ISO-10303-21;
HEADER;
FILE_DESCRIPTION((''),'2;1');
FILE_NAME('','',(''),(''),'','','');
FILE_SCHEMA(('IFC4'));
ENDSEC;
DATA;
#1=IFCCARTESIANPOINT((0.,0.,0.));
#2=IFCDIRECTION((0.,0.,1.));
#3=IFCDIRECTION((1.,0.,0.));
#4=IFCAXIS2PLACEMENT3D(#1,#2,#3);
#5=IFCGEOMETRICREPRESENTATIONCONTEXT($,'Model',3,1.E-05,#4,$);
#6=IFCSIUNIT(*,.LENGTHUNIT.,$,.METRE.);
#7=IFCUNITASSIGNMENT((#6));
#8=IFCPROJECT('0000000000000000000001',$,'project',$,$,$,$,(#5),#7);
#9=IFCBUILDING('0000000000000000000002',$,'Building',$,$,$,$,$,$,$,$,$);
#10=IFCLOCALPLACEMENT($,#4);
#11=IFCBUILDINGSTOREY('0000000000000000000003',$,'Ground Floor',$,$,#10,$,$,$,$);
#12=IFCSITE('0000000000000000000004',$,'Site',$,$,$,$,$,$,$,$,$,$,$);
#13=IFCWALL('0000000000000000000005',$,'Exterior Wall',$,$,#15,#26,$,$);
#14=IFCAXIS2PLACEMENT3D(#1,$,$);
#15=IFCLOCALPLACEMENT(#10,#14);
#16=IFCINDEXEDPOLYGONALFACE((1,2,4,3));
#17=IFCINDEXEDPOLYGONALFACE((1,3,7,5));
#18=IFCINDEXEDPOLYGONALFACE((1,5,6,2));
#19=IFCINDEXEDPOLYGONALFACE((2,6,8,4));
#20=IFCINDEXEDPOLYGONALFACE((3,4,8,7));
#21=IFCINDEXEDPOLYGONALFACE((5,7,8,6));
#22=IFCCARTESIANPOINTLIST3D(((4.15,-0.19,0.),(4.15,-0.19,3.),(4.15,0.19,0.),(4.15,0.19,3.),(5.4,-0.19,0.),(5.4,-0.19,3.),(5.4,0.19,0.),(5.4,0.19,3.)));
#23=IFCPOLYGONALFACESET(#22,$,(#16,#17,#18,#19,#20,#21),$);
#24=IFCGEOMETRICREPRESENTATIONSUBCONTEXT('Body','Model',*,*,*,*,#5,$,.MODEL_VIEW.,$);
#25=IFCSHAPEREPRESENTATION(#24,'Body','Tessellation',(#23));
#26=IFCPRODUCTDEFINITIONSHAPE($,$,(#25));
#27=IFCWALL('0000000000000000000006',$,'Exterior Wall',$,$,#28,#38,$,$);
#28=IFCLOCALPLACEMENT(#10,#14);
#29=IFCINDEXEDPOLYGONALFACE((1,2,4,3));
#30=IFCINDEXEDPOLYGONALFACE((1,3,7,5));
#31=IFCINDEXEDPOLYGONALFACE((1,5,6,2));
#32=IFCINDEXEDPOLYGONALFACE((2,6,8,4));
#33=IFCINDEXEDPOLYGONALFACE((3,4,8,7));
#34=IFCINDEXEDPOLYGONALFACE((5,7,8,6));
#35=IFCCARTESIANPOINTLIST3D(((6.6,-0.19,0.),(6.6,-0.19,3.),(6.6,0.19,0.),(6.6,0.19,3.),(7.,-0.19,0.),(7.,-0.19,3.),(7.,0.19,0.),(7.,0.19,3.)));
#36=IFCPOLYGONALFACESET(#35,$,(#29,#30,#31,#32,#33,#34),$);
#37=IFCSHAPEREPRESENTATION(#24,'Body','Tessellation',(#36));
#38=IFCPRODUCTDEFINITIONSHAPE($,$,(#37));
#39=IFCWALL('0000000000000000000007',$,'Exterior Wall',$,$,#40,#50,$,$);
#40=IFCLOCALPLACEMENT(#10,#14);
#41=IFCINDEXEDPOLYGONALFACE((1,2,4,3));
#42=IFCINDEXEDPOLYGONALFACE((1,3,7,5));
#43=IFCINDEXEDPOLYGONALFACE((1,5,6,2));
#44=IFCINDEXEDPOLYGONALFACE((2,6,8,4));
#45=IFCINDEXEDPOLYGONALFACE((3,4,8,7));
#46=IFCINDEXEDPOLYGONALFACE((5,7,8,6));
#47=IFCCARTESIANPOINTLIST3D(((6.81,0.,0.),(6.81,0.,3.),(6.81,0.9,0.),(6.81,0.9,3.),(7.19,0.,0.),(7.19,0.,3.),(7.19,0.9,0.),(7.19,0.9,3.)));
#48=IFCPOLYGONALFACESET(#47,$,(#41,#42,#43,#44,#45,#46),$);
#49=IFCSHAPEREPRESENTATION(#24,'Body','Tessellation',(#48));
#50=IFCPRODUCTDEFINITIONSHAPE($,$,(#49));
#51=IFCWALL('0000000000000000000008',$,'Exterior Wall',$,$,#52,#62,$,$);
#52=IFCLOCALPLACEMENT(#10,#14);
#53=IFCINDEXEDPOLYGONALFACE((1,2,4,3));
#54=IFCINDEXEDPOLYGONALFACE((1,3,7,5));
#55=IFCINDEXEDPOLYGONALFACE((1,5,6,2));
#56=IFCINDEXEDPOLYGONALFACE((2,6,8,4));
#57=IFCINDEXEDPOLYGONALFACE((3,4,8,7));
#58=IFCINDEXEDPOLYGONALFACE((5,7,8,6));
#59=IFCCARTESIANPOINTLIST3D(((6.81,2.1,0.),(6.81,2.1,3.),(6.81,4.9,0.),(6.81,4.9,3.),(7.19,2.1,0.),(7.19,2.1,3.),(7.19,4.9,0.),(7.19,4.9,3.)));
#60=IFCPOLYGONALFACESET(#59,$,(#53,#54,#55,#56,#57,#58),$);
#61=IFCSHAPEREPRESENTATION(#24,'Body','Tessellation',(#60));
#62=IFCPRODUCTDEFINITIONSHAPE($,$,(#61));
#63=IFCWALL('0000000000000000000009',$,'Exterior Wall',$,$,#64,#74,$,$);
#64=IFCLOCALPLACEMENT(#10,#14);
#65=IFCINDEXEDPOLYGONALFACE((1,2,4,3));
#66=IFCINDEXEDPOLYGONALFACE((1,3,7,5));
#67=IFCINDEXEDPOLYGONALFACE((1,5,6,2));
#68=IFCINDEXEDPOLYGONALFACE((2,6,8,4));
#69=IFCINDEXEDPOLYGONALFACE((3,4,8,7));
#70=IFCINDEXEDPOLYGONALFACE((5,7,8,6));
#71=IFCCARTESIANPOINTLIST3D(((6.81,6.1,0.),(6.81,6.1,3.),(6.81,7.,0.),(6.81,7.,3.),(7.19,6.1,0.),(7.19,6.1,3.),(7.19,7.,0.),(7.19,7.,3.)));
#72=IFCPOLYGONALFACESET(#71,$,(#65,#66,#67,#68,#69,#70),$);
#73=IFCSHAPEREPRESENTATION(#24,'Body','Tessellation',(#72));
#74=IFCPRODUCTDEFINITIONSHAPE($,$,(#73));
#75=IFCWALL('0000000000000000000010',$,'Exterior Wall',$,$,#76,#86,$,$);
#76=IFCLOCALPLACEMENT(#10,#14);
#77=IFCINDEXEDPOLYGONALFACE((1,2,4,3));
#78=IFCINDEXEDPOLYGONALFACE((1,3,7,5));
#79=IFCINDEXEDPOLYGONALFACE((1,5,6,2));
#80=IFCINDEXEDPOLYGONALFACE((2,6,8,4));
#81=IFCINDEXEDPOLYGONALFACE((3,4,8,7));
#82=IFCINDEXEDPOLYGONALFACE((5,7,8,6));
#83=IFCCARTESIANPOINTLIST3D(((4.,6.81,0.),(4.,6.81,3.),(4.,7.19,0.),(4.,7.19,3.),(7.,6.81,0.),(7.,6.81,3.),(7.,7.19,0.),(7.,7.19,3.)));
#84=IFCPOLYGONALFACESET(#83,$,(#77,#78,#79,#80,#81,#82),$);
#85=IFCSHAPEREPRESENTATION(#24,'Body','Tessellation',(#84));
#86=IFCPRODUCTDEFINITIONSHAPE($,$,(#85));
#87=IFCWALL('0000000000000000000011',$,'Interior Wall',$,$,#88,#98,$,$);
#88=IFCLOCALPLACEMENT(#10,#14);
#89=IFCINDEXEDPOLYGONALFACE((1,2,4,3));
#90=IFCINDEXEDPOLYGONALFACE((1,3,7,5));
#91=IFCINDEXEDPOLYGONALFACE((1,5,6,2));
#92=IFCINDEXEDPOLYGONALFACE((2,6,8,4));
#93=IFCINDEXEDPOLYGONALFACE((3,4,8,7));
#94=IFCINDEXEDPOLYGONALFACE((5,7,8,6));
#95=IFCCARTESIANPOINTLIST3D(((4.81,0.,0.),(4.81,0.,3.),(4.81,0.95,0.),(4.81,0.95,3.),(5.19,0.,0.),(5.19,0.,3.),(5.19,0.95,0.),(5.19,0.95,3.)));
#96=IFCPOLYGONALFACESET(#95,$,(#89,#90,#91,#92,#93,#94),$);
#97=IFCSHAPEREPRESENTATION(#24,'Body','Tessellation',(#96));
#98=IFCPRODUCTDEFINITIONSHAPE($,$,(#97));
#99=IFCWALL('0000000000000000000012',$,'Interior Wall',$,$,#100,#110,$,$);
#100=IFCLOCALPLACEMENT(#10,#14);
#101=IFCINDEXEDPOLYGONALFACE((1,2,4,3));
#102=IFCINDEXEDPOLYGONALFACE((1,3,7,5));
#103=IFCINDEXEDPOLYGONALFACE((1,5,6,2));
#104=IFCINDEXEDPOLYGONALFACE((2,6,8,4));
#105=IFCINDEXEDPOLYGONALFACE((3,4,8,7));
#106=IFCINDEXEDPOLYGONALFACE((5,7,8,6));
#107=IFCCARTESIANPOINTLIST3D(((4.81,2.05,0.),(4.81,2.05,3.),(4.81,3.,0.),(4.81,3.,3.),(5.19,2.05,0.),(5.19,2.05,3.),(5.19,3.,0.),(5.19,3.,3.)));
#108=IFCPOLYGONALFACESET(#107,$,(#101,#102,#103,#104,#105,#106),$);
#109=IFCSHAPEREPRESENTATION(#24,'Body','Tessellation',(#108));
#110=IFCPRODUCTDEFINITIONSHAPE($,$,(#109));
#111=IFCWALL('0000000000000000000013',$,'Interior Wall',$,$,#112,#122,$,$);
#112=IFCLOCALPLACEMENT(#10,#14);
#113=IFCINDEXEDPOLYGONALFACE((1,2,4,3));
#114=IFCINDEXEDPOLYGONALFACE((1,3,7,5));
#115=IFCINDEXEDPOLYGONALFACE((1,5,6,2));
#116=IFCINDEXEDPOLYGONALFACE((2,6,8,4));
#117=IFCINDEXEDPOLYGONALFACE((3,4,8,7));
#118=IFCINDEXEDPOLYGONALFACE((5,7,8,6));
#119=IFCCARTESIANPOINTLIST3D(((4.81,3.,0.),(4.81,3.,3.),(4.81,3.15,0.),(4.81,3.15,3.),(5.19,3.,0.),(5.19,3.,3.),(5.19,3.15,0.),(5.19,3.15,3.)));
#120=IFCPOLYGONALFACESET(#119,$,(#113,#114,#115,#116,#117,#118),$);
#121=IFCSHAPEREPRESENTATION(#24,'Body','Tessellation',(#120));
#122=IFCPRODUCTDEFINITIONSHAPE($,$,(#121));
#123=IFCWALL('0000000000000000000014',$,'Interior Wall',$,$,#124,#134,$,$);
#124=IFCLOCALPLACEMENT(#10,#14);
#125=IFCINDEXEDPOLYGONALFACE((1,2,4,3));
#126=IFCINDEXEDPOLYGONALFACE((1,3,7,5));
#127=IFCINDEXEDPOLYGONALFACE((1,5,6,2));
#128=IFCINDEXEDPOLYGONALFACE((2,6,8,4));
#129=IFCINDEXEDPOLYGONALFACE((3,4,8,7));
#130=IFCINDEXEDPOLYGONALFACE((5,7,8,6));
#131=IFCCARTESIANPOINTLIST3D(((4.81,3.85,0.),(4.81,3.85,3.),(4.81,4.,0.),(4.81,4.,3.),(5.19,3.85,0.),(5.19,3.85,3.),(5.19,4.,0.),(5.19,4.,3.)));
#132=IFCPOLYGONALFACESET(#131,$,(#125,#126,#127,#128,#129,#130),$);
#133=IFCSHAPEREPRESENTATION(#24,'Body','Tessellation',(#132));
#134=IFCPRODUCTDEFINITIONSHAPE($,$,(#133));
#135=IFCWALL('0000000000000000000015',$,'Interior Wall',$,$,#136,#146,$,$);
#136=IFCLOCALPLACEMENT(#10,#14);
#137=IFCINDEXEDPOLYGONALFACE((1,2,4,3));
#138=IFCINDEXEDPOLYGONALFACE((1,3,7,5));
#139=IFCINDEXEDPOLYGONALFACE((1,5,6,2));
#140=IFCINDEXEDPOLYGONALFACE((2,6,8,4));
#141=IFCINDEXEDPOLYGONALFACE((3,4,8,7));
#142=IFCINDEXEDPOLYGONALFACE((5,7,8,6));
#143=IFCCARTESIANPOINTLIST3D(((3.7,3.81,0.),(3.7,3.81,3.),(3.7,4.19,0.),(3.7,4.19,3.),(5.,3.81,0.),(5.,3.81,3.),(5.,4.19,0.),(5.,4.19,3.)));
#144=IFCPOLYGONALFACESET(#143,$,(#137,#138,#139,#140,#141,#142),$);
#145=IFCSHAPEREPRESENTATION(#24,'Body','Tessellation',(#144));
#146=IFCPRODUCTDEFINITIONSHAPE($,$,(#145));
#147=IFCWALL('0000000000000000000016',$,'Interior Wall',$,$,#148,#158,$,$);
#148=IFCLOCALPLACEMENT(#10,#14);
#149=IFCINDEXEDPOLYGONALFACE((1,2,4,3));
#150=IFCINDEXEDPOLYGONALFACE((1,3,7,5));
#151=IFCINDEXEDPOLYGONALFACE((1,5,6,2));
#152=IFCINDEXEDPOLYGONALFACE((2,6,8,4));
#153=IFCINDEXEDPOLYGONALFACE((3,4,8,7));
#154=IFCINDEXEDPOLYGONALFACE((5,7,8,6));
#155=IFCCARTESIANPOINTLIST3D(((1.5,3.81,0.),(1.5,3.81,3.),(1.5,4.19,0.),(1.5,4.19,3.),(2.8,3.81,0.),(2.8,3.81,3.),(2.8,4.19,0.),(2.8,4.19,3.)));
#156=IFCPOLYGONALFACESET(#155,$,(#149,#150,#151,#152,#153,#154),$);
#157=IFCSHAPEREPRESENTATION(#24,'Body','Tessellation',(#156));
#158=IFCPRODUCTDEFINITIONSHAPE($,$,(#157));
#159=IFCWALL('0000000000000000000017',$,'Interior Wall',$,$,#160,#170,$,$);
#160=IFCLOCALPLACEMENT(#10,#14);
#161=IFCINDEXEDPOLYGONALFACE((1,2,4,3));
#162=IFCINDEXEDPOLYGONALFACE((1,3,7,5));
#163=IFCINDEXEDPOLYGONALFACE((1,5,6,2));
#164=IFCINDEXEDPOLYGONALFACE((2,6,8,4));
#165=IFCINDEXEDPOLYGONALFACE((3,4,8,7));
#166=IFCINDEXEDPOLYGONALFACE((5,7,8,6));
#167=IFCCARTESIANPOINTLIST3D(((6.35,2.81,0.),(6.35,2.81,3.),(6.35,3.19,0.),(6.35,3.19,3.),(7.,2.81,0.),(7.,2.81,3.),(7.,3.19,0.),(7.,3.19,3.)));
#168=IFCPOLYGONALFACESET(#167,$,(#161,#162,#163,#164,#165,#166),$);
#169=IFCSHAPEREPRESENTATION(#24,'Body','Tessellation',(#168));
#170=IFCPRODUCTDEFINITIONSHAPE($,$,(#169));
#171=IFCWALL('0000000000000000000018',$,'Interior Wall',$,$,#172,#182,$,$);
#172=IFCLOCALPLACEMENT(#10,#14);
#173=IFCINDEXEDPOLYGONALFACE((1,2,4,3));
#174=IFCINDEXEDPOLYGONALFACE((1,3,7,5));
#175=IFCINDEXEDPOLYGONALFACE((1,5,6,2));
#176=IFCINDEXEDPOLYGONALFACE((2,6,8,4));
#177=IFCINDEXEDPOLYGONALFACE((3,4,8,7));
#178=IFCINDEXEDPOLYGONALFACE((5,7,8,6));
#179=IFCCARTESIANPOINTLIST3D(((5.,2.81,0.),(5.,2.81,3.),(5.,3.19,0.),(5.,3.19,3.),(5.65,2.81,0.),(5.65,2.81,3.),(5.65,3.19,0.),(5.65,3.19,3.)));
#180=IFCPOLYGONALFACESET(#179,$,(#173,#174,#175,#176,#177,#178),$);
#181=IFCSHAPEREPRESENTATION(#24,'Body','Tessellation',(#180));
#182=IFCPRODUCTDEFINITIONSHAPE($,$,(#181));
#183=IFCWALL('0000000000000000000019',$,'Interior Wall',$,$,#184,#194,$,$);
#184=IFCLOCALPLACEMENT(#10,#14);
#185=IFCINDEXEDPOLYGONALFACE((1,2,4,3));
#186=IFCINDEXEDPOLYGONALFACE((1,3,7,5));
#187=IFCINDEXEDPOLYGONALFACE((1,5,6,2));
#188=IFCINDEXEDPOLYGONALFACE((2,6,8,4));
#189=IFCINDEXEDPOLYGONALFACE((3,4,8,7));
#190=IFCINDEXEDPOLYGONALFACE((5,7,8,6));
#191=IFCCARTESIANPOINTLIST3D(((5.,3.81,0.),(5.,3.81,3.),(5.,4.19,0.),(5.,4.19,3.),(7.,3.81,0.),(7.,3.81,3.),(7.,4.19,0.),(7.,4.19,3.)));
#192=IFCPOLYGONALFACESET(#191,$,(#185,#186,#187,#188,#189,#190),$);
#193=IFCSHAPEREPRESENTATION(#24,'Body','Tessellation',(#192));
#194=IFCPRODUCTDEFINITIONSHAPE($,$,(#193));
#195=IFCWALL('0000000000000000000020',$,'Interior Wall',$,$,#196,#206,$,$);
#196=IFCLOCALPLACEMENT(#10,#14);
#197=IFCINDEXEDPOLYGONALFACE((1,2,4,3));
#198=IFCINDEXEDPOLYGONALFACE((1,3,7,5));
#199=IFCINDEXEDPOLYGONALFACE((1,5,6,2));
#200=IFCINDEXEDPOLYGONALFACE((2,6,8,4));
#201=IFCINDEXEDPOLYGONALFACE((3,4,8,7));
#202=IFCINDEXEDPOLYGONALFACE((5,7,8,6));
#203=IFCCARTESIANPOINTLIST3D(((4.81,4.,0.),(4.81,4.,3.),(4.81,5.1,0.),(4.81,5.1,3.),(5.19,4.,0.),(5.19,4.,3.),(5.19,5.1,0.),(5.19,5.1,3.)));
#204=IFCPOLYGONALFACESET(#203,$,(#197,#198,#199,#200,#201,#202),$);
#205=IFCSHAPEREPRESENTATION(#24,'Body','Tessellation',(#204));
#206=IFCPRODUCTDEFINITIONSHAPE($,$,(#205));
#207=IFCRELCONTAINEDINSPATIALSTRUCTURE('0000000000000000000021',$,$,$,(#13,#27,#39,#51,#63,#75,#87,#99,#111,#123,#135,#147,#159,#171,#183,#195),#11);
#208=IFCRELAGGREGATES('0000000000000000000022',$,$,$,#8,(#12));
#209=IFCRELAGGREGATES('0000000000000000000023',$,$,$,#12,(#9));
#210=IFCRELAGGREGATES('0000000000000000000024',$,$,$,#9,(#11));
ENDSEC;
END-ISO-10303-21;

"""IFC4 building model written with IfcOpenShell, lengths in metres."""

from ifc_helpers import new_model, si_unit, frame, origin_with_axes, place, context, subcontext, project, spatial, indexed_curve, outline, extrude, element, save


model = new_model("IFC4")

# Units and contexts
model_context = context("Model", 3, precision=1e-05, world=origin_with_axes())
body_context = subcontext(model_context, "Body", "Model", "MODEL_VIEW")
ifc_project = project(units=[si_unit("LENGTHUNIT", "METRE")], contexts=[model_context])

# Site, building, storey
site = spatial("IfcSite", under=ifc_project, Name="Site")
building = spatial("IfcBuilding", under=site, Name="Building")
storey_placement = place(None, origin_with_axes())
storey = spatial("IfcBuildingStorey", under=building, at=storey_placement, Name="Ground Floor")

# Walls
wall_1_placement = place(storey_placement, frame((4.15, 0.0, 0.0), z_axis=(0.0, 0.0, 1.0), x_axis=(1.0, 0.0, 0.0)))
element("IfcWall", 1, at=wall_1_placement, inside=storey, Name="Exterior Wall", context=body_context, shape_type="SweptSolid", body=[
    extrude(outline(indexed_curve([(0.0, 0.0), (0.0, 0.38), (1.25, 0.38), (1.25, 0.0), (0.0, 0.0)], self_intersect=False)), frame((0.0, -0.19, 0.0), z_axis=(0.0, 0.0, 1.0), x_axis=(1.0, 0.0, 0.0)), (0.0, 0.0, 1.0), 3.0),
])
wall_2_placement = place(storey_placement, frame((6.6, 0.0, 0.0), z_axis=(0.0, 0.0, 1.0), x_axis=(1.0, 0.0, 0.0)))
element("IfcWall", 2, at=wall_2_placement, inside=storey, Name="Exterior Wall", context=body_context, shape_type="SweptSolid", body=[
    extrude(outline(indexed_curve([(0.0, 0.0), (0.0, 0.38), (0.4, 0.38), (0.4, 0.0), (0.0, 0.0)], self_intersect=False)), frame((0.0, -0.19, 0.0), z_axis=(0.0, 0.0, 1.0), x_axis=(1.0, 0.0, 0.0)), (0.0, 0.0, 1.0), 3.0),
])
wall_3_placement = place(storey_placement, frame((7.0, 0.0, 0.0), z_axis=(0.0, 0.0, 1.0), x_axis=(0.0, 1.0, 0.0)))
element("IfcWall", 3, at=wall_3_placement, inside=storey, Name="Exterior Wall", context=body_context, shape_type="SweptSolid", body=[
    extrude(outline(indexed_curve([(0.0, 0.0), (0.0, 0.38), (0.9, 0.38), (0.9, 0.0), (0.0, 0.0)], self_intersect=False)), frame((0.0, -0.19, 0.0), z_axis=(0.0, 0.0, 1.0), x_axis=(1.0, 0.0, 0.0)), (0.0, 0.0, 1.0), 3.0),
])
wall_4_placement = place(storey_placement, frame((7.0, 2.1, 0.0), z_axis=(0.0, 0.0, 1.0), x_axis=(0.0, 1.0, 0.0)))
element("IfcWall", 4, at=wall_4_placement, inside=storey, Name="Exterior Wall", context=body_context, shape_type="SweptSolid", body=[
    extrude(outline(indexed_curve([(0.0, 0.0), (0.0, 0.38), (2.8, 0.38), (2.8, 0.0), (0.0, 0.0)], self_intersect=False)), frame((0.0, -0.19, 0.0), z_axis=(0.0, 0.0, 1.0), x_axis=(1.0, 0.0, 0.0)), (0.0, 0.0, 1.0), 3.0),
])
wall_5_placement = place(storey_placement, frame((7.0, 6.1, 0.0), z_axis=(0.0, 0.0, 1.0), x_axis=(0.0, 1.0, 0.0)))
element("IfcWall", 5, at=wall_5_placement, inside=storey, Name="Exterior Wall", context=body_context, shape_type="SweptSolid", body=[
    extrude(outline(indexed_curve([(0.0, 0.0), (0.0, 0.38), (0.9, 0.38), (0.9, 0.0), (0.0, 0.0)], self_intersect=False)), frame((0.0, -0.19, 0.0), z_axis=(0.0, 0.0, 1.0), x_axis=(1.0, 0.0, 0.0)), (0.0, 0.0, 1.0), 3.0),
])
wall_6_placement = place(storey_placement, frame((7.0, 7.0, 0.0), z_axis=(0.0, 0.0, 1.0), x_axis=(-1.0, 0.0, 0.0)))
element("IfcWall", 6, at=wall_6_placement, inside=storey, Name="Exterior Wall", context=body_context, shape_type="SweptSolid", body=[
    extrude(outline(indexed_curve([(0.0, 0.0), (0.0, 0.38), (3.0, 0.38), (3.0, 0.0), (0.0, 0.0)], self_intersect=False)), frame((0.0, -0.19, 0.0), z_axis=(0.0, 0.0, 1.0), x_axis=(1.0, 0.0, 0.0)), (0.0, 0.0, 1.0), 3.0),
])
wall_7_placement = place(storey_placement, frame((5.0, 0.0, 0.0), z_axis=(0.0, 0.0, 1.0), x_axis=(0.0, 1.0, 0.0)))
element("IfcWall", 7, at=wall_7_placement, inside=storey, Name="Interior Wall", context=body_context, shape_type="SweptSolid", body=[
    extrude(outline(indexed_curve([(0.0, 0.0), (0.0, 0.38), (0.95, 0.38), (0.95, 0.0), (0.0, 0.0)], self_intersect=False)), frame((0.0, -0.19, 0.0), z_axis=(0.0, 0.0, 1.0), x_axis=(1.0, 0.0, 0.0)), (0.0, 0.0, 1.0), 3.0),
])
wall_8_placement = place(storey_placement, frame((5.0, 2.05, 0.0), z_axis=(0.0, 0.0, 1.0), x_axis=(0.0, 1.0, 0.0)))
element("IfcWall", 8, at=wall_8_placement, inside=storey, Name="Interior Wall", context=body_context, shape_type="SweptSolid", body=[
    extrude(outline(indexed_curve([(0.0, 0.0), (0.0, 0.38), (0.95, 0.38), (0.95, 0.0), (0.0, 0.0)], self_intersect=False)), frame((0.0, -0.19, 0.0), z_axis=(0.0, 0.0, 1.0), x_axis=(1.0, 0.0, 0.0)), (0.0, 0.0, 1.0), 3.0),
])
for number, where, z_axis, x_axis, name in (
    (9, (5.0, 3.0, 0.0), (0.0, 0.0, 1.0), (0.0, 1.0, 0.0), "Interior Wall"),
    (10, (5.0, 3.85, 0.0), (0.0, 0.0, 1.0), (0.0, 1.0, 0.0), "Interior Wall"),
):
    element("IfcWall", number, at=place(storey_placement, frame(where, z_axis=z_axis, x_axis=x_axis)), inside=storey, Name=name, context=body_context, shape_type="SweptSolid", body=[
        extrude(outline(indexed_curve([(0.0, 0.0), (0.0, 0.38), (0.15, 0.38), (0.15, 0.0), (0.0, 0.0)], self_intersect=False)), frame((0.0, -0.19, 0.0), z_axis=(0.0, 0.0, 1.0), x_axis=(1.0, 0.0, 0.0)), (0.0, 0.0, 1.0), 3.0),
    ])
for number, where, z_axis, x_axis, name in (
    (11, (5.0, 4.0, 0.0), (0.0, 0.0, 1.0), (-1.0, 0.0, 0.0), "Interior Wall"),
    (12, (2.8, 4.0, 0.0), (0.0, 0.0, 1.0), (-1.0, 0.0, 0.0), "Interior Wall"),
):
    element("IfcWall", number, at=place(storey_placement, frame(where, z_axis=z_axis, x_axis=x_axis)), inside=storey, Name=name, context=body_context, shape_type="SweptSolid", body=[
        extrude(outline(indexed_curve([(0.0, 0.0), (0.0, 0.38), (1.3, 0.38), (1.3, 0.0), (0.0, 0.0)], self_intersect=False)), frame((0.0, -0.19, 0.0), z_axis=(0.0, 0.0, 1.0), x_axis=(1.0, 0.0, 0.0)), (0.0, 0.0, 1.0), 3.0),
    ])
for number, where, z_axis, x_axis, name in (
    (13, (7.0, 3.0, 0.0), (0.0, 0.0, 1.0), (-1.0, 0.0, 0.0), "Interior Wall"),
    (14, (5.65, 3.0, 0.0), (0.0, 0.0, 1.0), (-1.0, 0.0, 0.0), "Interior Wall"),
):
    element("IfcWall", number, at=place(storey_placement, frame(where, z_axis=z_axis, x_axis=x_axis)), inside=storey, Name=name, context=body_context, shape_type="SweptSolid", body=[
        extrude(outline(indexed_curve([(0.0, 0.0), (0.0, 0.38), (0.65, 0.38), (0.65, 0.0), (0.0, 0.0)], self_intersect=False)), frame((0.0, -0.19, 0.0), z_axis=(0.0, 0.0, 1.0), x_axis=(1.0, 0.0, 0.0)), (0.0, 0.0, 1.0), 3.0),
    ])
wall_9_placement = place(storey_placement, frame((7.0, 4.0, 0.0), z_axis=(0.0, 0.0, 1.0), x_axis=(-1.0, 0.0, 0.0)))
element("IfcWall", 15, at=wall_9_placement, inside=storey, Name="Interior Wall", context=body_context, shape_type="SweptSolid", body=[
    extrude(outline(indexed_curve([(0.0, 0.0), (0.0, 0.38), (2.0, 0.38), (2.0, 0.0), (0.0, 0.0)], self_intersect=False)), frame((0.0, -0.19, 0.0), z_axis=(0.0, 0.0, 1.0), x_axis=(1.0, 0.0, 0.0)), (0.0, 0.0, 1.0), 3.0),
])
for number, where, z_axis, x_axis, name in (
    (16, (5.0, 4.0, 0.0), (0.0, 0.0, 1.0), (0.0, 1.0, 0.0), "Interior Wall"),
):
    element("IfcWall", number, at=place(storey_placement, frame(where, z_axis=z_axis, x_axis=x_axis)), inside=storey, Name=name, context=body_context, shape_type="SweptSolid", body=[
        extrude(outline(indexed_curve([(0.0, 0.0), (0.0, 0.38), (1.1, 0.38), (1.1, 0.0), (0.0, 0.0)], self_intersect=False)), frame((0.0, -0.19, 0.0), z_axis=(0.0, 0.0, 1.0), x_axis=(1.0, 0.0, 0.0)), (0.0, 0.0, 1.0), 3.0),
    ])

save(model, "model.ifc")
